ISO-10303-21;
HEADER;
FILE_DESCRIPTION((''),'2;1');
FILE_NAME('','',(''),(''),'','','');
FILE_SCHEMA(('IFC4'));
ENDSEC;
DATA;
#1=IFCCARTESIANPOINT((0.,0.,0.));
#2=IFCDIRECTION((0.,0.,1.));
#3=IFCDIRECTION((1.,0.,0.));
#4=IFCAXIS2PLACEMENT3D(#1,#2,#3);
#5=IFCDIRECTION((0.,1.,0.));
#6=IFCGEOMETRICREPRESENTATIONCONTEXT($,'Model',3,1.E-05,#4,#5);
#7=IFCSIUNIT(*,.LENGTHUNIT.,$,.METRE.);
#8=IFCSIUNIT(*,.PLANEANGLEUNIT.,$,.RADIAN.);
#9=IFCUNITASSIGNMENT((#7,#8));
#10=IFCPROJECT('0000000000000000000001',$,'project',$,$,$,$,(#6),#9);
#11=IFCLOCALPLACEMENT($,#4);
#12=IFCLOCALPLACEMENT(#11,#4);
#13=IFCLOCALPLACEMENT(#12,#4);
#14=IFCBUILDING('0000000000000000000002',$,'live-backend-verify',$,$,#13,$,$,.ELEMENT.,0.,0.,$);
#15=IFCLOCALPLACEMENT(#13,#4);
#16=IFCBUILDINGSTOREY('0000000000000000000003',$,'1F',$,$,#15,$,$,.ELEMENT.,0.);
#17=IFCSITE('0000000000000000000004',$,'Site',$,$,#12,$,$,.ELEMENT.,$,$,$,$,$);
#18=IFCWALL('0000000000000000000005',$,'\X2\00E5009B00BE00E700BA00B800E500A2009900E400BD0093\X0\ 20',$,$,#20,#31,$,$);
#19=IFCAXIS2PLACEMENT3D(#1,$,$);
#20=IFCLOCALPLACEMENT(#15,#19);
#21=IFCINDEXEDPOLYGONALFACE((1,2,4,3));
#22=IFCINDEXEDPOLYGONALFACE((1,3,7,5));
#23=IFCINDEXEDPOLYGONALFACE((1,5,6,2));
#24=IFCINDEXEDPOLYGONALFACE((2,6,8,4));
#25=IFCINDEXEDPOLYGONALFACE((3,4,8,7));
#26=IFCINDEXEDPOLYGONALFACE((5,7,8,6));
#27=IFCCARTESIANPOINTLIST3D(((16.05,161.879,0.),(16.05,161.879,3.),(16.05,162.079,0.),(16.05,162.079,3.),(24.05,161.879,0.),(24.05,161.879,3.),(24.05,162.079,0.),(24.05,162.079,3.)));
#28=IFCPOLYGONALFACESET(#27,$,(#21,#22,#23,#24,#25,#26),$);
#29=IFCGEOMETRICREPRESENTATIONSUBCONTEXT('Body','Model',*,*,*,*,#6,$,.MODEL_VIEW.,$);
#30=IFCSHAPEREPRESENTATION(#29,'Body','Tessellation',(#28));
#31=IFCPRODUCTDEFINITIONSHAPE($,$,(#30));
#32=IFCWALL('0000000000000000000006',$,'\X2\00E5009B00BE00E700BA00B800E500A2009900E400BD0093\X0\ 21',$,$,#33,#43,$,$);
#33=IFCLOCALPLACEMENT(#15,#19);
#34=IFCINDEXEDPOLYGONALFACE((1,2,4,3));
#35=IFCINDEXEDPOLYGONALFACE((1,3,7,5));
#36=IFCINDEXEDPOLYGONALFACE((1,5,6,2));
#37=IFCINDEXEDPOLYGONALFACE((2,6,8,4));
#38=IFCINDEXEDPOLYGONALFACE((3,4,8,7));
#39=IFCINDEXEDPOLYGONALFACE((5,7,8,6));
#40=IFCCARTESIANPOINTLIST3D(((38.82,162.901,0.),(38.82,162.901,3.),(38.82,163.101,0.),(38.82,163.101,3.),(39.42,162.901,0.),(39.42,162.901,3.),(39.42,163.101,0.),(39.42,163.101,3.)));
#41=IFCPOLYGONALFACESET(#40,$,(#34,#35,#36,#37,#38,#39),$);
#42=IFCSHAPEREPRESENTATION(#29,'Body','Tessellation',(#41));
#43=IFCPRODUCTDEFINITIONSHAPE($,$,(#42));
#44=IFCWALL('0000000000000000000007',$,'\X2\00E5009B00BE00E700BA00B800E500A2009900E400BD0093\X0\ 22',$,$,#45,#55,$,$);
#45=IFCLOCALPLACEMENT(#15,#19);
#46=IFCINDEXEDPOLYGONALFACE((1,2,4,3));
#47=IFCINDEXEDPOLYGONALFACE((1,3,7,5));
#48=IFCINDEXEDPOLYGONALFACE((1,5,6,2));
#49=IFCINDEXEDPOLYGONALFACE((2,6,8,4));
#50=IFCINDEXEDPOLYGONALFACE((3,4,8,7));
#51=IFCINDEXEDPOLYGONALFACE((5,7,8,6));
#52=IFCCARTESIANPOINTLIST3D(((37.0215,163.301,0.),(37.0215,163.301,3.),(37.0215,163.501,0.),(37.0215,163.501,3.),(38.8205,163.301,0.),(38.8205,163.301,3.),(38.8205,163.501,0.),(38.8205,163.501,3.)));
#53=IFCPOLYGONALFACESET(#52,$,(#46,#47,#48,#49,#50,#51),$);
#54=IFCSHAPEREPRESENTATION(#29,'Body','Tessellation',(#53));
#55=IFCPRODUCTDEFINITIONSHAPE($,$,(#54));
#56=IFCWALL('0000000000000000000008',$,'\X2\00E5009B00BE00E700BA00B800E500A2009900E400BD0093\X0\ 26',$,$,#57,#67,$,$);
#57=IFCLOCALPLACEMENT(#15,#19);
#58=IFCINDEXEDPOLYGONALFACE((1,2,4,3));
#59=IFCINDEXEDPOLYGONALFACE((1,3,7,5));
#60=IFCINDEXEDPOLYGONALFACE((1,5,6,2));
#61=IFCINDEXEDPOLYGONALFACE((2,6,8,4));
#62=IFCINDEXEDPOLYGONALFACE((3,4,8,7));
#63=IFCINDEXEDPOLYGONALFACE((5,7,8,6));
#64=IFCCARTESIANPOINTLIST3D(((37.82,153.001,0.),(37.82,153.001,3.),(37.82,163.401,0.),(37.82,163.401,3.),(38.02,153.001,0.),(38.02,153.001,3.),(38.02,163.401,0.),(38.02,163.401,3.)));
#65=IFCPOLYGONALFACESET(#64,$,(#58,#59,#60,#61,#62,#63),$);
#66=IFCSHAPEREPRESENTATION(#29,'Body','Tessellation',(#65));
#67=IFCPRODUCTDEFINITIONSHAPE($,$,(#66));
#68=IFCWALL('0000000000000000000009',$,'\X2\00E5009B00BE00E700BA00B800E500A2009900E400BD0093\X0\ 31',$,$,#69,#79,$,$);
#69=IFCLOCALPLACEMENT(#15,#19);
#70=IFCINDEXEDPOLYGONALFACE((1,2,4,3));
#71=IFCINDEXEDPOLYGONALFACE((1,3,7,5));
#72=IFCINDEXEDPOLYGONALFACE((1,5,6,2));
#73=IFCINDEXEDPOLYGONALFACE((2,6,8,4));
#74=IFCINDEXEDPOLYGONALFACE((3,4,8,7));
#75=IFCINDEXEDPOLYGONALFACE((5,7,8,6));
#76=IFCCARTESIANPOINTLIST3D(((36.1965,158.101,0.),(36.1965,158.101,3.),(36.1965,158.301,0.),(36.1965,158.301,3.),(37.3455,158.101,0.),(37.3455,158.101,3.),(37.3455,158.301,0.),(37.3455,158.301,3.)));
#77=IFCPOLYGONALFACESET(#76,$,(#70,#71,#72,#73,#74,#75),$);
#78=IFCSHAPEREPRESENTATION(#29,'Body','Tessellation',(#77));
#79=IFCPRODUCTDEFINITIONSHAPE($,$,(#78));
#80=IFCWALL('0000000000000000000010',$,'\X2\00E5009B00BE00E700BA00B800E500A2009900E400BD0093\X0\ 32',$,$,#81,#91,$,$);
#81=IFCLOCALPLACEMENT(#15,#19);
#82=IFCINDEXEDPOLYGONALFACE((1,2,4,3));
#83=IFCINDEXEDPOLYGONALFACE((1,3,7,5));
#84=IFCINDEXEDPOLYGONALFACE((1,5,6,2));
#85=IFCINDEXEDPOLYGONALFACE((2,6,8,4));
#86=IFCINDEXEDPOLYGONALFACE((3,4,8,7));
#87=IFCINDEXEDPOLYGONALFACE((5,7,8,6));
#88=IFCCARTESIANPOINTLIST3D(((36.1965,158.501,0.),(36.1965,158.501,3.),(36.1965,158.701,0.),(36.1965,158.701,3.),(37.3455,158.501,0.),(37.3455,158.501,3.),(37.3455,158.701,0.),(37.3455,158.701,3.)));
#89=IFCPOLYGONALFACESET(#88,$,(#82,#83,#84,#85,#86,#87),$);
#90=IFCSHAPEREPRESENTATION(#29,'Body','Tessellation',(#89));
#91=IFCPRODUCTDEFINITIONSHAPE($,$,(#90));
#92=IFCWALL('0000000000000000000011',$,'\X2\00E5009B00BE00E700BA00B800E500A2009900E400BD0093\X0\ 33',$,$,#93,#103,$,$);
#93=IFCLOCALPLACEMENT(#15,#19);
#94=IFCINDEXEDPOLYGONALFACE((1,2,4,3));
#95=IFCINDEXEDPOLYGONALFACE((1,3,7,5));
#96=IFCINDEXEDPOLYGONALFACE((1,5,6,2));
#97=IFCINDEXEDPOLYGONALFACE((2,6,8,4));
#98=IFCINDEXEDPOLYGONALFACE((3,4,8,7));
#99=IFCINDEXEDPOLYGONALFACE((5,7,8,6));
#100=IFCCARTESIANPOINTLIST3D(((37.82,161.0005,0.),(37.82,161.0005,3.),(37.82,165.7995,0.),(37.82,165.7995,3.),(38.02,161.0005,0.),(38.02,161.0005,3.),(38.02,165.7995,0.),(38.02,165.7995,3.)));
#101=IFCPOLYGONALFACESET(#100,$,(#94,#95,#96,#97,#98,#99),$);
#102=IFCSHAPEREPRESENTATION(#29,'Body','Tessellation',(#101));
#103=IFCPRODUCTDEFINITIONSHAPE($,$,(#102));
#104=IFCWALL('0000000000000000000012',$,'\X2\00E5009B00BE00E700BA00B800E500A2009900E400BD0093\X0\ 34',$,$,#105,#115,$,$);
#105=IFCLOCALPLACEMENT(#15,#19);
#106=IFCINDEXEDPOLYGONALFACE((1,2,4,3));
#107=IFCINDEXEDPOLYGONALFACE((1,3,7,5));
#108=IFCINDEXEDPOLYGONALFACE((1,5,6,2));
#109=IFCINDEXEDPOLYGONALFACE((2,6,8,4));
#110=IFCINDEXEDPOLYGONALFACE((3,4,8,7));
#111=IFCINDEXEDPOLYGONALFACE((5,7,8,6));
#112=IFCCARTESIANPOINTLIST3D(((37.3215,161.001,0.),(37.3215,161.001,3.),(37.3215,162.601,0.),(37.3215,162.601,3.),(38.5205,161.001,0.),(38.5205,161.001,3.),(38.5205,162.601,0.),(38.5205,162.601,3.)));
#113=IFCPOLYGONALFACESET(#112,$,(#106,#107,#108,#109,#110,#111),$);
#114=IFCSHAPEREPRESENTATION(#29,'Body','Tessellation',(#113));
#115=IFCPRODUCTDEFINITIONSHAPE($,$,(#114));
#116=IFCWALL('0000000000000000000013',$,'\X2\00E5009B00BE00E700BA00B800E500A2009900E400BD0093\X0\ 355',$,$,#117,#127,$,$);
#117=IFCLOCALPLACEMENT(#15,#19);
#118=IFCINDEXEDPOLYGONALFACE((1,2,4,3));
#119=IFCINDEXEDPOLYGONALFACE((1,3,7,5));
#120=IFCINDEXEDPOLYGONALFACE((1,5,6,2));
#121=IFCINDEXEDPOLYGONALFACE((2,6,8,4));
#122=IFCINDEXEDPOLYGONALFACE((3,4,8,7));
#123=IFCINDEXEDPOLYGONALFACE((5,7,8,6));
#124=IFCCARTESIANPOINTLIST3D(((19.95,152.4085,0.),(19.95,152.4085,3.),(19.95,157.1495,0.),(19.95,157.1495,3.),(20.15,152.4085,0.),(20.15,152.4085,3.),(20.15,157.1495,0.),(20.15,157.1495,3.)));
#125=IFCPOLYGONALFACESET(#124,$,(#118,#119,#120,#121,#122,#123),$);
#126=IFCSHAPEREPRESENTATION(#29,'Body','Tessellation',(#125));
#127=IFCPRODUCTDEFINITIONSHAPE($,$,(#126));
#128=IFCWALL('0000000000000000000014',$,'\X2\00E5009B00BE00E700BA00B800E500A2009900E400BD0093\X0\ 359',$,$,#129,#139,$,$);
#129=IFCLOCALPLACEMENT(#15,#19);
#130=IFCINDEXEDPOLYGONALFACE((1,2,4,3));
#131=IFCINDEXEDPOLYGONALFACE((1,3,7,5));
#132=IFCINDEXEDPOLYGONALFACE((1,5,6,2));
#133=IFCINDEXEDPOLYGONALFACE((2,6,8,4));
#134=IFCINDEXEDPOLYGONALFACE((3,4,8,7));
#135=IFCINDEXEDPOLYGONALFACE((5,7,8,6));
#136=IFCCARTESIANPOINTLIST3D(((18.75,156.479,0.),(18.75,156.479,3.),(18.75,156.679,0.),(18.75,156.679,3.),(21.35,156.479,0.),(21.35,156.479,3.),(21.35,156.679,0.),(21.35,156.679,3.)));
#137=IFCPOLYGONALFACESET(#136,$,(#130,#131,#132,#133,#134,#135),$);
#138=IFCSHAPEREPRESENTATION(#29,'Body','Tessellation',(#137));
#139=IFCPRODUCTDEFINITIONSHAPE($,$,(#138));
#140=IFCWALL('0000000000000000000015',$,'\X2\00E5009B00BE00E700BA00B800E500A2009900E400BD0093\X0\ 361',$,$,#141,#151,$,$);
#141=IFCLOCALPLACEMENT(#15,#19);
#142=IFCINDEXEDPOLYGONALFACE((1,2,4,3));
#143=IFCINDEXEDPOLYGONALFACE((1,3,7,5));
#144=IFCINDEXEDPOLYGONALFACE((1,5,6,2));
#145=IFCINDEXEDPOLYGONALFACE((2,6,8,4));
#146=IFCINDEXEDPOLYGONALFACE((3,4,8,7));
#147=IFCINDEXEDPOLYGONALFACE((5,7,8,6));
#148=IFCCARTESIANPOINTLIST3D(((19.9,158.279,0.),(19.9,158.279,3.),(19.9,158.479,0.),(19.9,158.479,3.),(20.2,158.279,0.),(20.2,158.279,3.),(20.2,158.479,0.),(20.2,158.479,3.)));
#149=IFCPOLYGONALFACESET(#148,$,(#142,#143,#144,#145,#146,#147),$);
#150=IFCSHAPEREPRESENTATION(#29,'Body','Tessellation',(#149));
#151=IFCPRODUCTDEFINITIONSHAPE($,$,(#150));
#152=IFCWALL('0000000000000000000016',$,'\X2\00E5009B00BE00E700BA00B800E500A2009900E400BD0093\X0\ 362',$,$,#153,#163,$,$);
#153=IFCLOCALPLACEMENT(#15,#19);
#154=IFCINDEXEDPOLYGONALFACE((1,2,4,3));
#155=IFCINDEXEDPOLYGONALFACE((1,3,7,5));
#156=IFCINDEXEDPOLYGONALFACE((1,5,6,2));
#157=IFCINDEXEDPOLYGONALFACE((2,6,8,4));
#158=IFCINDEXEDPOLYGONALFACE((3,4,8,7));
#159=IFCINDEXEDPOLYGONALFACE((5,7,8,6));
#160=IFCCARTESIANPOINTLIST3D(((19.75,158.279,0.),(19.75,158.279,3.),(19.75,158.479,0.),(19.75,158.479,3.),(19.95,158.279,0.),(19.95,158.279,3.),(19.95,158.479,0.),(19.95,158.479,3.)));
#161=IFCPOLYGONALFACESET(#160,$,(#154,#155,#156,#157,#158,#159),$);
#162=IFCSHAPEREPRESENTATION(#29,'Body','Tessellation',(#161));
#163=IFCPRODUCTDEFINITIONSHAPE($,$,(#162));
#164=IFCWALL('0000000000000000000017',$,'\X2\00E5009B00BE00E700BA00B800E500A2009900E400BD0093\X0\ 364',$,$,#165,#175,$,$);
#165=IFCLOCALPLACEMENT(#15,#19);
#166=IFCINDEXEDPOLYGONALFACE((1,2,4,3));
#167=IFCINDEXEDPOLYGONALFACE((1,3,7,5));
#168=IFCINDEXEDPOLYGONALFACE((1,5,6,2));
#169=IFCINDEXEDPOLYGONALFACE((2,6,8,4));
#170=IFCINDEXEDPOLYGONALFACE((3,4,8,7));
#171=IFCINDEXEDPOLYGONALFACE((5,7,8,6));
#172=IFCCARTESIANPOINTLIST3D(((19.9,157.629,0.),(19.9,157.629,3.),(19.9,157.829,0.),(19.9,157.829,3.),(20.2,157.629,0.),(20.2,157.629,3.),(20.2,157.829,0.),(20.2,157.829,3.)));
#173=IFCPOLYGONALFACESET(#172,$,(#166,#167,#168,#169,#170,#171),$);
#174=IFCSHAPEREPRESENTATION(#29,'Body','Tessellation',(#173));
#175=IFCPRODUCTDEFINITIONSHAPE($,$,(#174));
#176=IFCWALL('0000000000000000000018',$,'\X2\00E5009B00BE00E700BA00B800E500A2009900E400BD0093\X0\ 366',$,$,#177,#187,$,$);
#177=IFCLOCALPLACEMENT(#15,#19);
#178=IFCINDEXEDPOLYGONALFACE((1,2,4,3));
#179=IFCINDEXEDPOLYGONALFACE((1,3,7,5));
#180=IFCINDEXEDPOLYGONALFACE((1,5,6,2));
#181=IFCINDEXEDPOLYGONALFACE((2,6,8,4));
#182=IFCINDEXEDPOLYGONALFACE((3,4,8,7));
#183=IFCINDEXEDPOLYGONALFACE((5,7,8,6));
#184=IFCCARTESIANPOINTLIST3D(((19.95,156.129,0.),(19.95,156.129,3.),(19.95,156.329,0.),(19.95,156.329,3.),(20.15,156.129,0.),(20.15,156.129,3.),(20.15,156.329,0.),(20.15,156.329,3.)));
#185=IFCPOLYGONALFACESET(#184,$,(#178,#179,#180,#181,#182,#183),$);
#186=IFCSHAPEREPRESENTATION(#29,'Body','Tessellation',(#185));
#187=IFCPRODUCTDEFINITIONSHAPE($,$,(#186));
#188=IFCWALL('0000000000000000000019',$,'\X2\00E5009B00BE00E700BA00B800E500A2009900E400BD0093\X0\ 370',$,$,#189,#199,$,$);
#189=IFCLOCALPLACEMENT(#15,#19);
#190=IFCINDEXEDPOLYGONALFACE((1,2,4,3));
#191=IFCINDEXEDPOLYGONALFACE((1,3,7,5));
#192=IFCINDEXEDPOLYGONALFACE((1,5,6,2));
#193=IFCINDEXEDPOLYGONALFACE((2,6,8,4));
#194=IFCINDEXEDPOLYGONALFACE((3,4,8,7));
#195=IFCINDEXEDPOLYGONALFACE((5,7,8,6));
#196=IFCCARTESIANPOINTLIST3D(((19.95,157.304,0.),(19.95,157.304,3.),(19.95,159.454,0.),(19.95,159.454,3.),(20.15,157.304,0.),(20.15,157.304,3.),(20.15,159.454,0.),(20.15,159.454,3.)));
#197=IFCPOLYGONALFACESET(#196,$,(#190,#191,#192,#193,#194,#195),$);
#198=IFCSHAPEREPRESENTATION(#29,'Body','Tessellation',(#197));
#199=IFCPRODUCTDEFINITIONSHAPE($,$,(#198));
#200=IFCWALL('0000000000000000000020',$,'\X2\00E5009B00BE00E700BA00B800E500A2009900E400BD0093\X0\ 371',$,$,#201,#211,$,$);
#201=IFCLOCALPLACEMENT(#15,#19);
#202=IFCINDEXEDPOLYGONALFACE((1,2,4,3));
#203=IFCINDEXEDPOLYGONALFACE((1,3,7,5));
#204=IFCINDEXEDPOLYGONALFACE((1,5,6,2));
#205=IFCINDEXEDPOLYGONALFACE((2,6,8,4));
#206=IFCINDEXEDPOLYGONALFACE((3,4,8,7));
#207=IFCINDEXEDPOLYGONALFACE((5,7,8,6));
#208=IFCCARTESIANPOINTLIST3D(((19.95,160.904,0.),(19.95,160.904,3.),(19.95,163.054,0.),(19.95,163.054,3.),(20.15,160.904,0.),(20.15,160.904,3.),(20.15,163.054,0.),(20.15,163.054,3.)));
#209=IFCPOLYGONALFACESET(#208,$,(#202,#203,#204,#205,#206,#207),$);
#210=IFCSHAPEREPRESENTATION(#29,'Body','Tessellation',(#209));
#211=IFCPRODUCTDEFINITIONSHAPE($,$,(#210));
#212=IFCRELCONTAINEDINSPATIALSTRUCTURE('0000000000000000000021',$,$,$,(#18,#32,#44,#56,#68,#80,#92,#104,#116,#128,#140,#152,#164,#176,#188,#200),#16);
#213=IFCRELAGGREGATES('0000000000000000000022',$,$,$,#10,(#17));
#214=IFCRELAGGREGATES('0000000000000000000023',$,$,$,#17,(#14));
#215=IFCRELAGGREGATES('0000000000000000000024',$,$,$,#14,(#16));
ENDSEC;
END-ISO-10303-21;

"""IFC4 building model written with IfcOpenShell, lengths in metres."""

from ifc_helpers import new_model, si_unit, direction, frame, frame_2d, origin_with_axes, place, context, subcontext, project, spatial, rectangle, extrude, element, save


model = new_model("IFC4")

# Units and contexts
model_context = context("Model", 3, precision=1e-05, world=origin_with_axes(), true_north=direction((0.0, 1.0, 0.0)))
body_context = subcontext(model_context, "Body", "Model", "MODEL_VIEW")
ifc_project = project(units=[si_unit("LENGTHUNIT", "METRE"), si_unit("PLANEANGLEUNIT", "RADIAN")], contexts=[model_context])

# Site, building, storey
placement = place(None, origin_with_axes())
site_placement = place(placement, origin_with_axes())
site = spatial("IfcSite", under=ifc_project, at=site_placement, Name="Site", CompositionType="ELEMENT")
building_placement = place(site_placement, origin_with_axes())
building = spatial("IfcBuilding", under=site, at=building_placement, Name="live-backend-verify", CompositionType="ELEMENT", ElevationOfRefHeight=0.0, ElevationOfTerrain=0.0)
storey_placement = place(building_placement, origin_with_axes())
storey = spatial("IfcBuildingStorey", under=building, at=storey_placement, Name="1F", CompositionType="ELEMENT", Elevation=0.0)

# Walls
wall_1_placement = place(storey_placement, frame((20.05, 161.979, 0.0), z_axis=(0.0, 0.0, 1.0), x_axis=(-1.0, 0.0, 0.0)))
element("IfcWall", 1, at=wall_1_placement, inside=storey, Name="å\u009b¾çº¸å¢\u0099ä½\u0093 20", context=body_context, shape_type="SweptSolid", body=[
    extrude(rectangle(XDim=8.0, YDim=0.2, at=frame_2d((0.0, 0.0), x_axis=(1.0, 0.0, 0.0))), frame((0.0, 0.0, 0.0), z_axis=(0.0, 0.0, 1.0)), (0.0, 0.0, 1.0), 3.0),
])
wall_2_placement = place(storey_placement, frame((39.12, 163.001, 0.0), z_axis=(0.0, 0.0, 1.0), x_axis=(1.0, 0.0, 0.0)))
element("IfcWall", 2, at=wall_2_placement, inside=storey, Name="å\u009b¾çº¸å¢\u0099ä½\u0093 21", context=body_context, shape_type="SweptSolid", body=[
    extrude(rectangle(XDim=0.6, YDim=0.2, at=frame_2d((0.0, 0.0), x_axis=(1.0, 0.0, 0.0))), frame((0.0, 0.0, 0.0), z_axis=(0.0, 0.0, 1.0)), (0.0, 0.0, 1.0), 3.0),
])
wall_3_placement = place(storey_placement, frame((37.921, 163.401, 0.0), z_axis=(0.0, 0.0, 1.0), x_axis=(1.0, 0.0, 0.0)))
element("IfcWall", 3, at=wall_3_placement, inside=storey, Name="å\u009b¾çº¸å¢\u0099ä½\u0093 22", context=body_context, shape_type="SweptSolid", body=[
    extrude(rectangle(XDim=1.799, YDim=0.2, at=frame_2d((0.0, 0.0), x_axis=(1.0, 0.0, 0.0))), frame((0.0, 0.0, 0.0), z_axis=(0.0, 0.0, 1.0)), (0.0, 0.0, 1.0), 3.0),
])
wall_4_placement = place(storey_placement, frame((37.92, 158.201, 0.0), z_axis=(0.0, 0.0, 1.0), x_axis=(0.0, -1.0, 0.0)))
element("IfcWall", 4, at=wall_4_placement, inside=storey, Name="å\u009b¾çº¸å¢\u0099ä½\u0093 26", context=body_context, shape_type="SweptSolid", body=[
    extrude(rectangle(XDim=10.4, YDim=0.2, at=frame_2d((0.0, 0.0), x_axis=(1.0, 0.0, 0.0))), frame((0.0, 0.0, 0.0), z_axis=(0.0, 0.0, 1.0)), (0.0, 0.0, 1.0), 3.0),
])
for number, where, z_axis, x_axis, name in (
    (5, (36.771, 158.201, 0.0), (0.0, 0.0, 1.0), (1.0, 0.0, 0.0), "å\u009b¾çº¸å¢\u0099ä½\u0093 31"),
    (6, (36.771, 158.601, 0.0), (0.0, 0.0, 1.0), (1.0, 0.0, 0.0), "å\u009b¾çº¸å¢\u0099ä½\u0093 32"),
):
    element("IfcWall", number, at=place(storey_placement, frame(where, z_axis=z_axis, x_axis=x_axis)), inside=storey, Name=name, context=body_context, shape_type="SweptSolid", body=[
        extrude(rectangle(XDim=1.149, YDim=0.2, at=frame_2d((0.0, 0.0), x_axis=(1.0, 0.0, 0.0))), frame((0.0, 0.0, 0.0), z_axis=(0.0, 0.0, 1.0)), (0.0, 0.0, 1.0), 3.0),
    ])
wall_5_placement = place(storey_placement, frame((37.92, 163.4, 0.0), z_axis=(0.0, 0.0, 1.0), x_axis=(0.0, -1.0, 0.0)))
element("IfcWall", 7, at=wall_5_placement, inside=storey, Name="å\u009b¾çº¸å¢\u0099ä½\u0093 33", context=body_context, shape_type="SweptSolid", body=[
    extrude(rectangle(XDim=4.799, YDim=0.2, at=frame_2d((0.0, 0.0), x_axis=(1.0, 0.0, 0.0))), frame((0.0, 0.0, 0.0), z_axis=(0.0, 0.0, 1.0)), (0.0, 0.0, 1.0), 3.0),
])
wall_6_placement = place(storey_placement, frame((37.921, 161.801, 0.0), z_axis=(0.0, 0.0, 1.0), x_axis=(1.0, 0.0, 0.0)))
element("IfcWall", 8, at=wall_6_placement, inside=storey, Name="å\u009b¾çº¸å¢\u0099ä½\u0093 34", context=body_context, shape_type="SweptSolid", body=[
    extrude(rectangle(XDim=1.199, YDim=1.6, at=frame_2d((0.0, 0.0), x_axis=(1.0, 0.0, 0.0))), frame((0.0, 0.0, 0.0), z_axis=(0.0, 0.0, 1.0)), (0.0, 0.0, 1.0), 3.0),
])
wall_7_placement = place(storey_placement, frame((20.05, 154.779, 0.0), z_axis=(0.0, 0.0, 1.0), x_axis=(0.0, -1.0, 0.0)))
element("IfcWall", 9, at=wall_7_placement, inside=storey, Name="å\u009b¾çº¸å¢\u0099ä½\u0093 355", context=body_context, shape_type="SweptSolid", body=[
    extrude(rectangle(XDim=4.741, YDim=0.2, at=frame_2d((0.0, 0.0), x_axis=(1.0, 0.0, 0.0))), frame((0.0, 0.0, 0.0), z_axis=(0.0, 0.0, 1.0)), (0.0, 0.0, 1.0), 3.0),
])
wall_8_placement = place(storey_placement, frame((20.05, 156.579, 0.0), z_axis=(0.0, 0.0, 1.0), x_axis=(-1.0, 0.0, 0.0)))
element("IfcWall", 10, at=wall_8_placement, inside=storey, Name="å\u009b¾çº¸å¢\u0099ä½\u0093 359", context=body_context, shape_type="SweptSolid", body=[
    extrude(rectangle(XDim=2.6, YDim=0.2, at=frame_2d((0.0, 0.0), x_axis=(1.0, 0.0, 0.0))), frame((0.0, 0.0, 0.0), z_axis=(0.0, 0.0, 1.0)), (0.0, 0.0, 1.0), 3.0),
])
wall_9_placement = place(storey_placement, frame((20.05, 158.379, 0.0), z_axis=(0.0, 0.0, 1.0), x_axis=(-1.0, 0.0, 0.0)))
element("IfcWall", 11, at=wall_9_placement, inside=storey, Name="å\u009b¾çº¸å¢\u0099ä½\u0093 361", context=body_context, shape_type="SweptSolid", body=[
    extrude(rectangle(XDim=0.3, YDim=0.2, at=frame_2d((0.0, 0.0), x_axis=(1.0, 0.0, 0.0))), frame((0.0, 0.0, 0.0), z_axis=(0.0, 0.0, 1.0)), (0.0, 0.0, 1.0), 3.0),
])
wall_10_placement = place(storey_placement, frame((19.85, 158.379, 0.0), z_axis=(0.0, 0.0, 1.0), x_axis=(1.0, 0.0, 0.0)))
element("IfcWall", 12, at=wall_10_placement, inside=storey, Name="å\u009b¾çº¸å¢\u0099ä½\u0093 362", context=body_context, shape_type="SweptSolid", body=[
    extrude(rectangle(XDim=0.2, YDim=0.2, at=frame_2d((0.0, 0.0), x_axis=(1.0, 0.0, 0.0))), frame((0.0, 0.0, 0.0), z_axis=(0.0, 0.0, 1.0)), (0.0, 0.0, 1.0), 3.0),
])
for number, where, z_axis, x_axis, name in (
    (13, (20.05, 157.729, 0.0), (0.0, 0.0, 1.0), (-1.0, 0.0, 0.0), "å\u009b¾çº¸å¢\u0099ä½\u0093 364"),
):
    element("IfcWall", number, at=place(storey_placement, frame(where, z_axis=z_axis, x_axis=x_axis)), inside=storey, Name=name, context=body_context, shape_type="SweptSolid", body=[
        extrude(rectangle(XDim=0.3, YDim=0.2, at=frame_2d((0.0, 0.0), x_axis=(1.0, 0.0, 0.0))), frame((0.0, 0.0, 0.0), z_axis=(0.0, 0.0, 1.0)), (0.0, 0.0, 1.0), 3.0),
    ])
wall_11_placement = place(storey_placement, frame((20.05, 156.229, 0.0), z_axis=(0.0, 0.0, 1.0), x_axis=(-1.0, 0.0, 0.0)))
element("IfcWall", 14, at=wall_11_placement, inside=storey, Name="å\u009b¾çº¸å¢\u0099ä½\u0093 366", context=body_context, shape_type="SweptSolid", body=[
    extrude(rectangle(XDim=0.2, YDim=0.2, at=frame_2d((0.0, 0.0), x_axis=(1.0, 0.0, 0.0))), frame((0.0, 0.0, 0.0), z_axis=(0.0, 0.0, 1.0)), (0.0, 0.0, 1.0), 3.0),
])
for number, where, z_axis, x_axis, name in (
    (15, (20.05, 158.379, 0.0), (0.0, 0.0, 1.0), (0.0, -1.0, 0.0), "å\u009b¾çº¸å¢\u0099ä½\u0093 370"),
    (16, (20.05, 161.979, 0.0), (0.0, 0.0, 1.0), (0.0, -1.0, 0.0), "å\u009b¾çº¸å¢\u0099ä½\u0093 371"),
):
    element("IfcWall", number, at=place(storey_placement, frame(where, z_axis=z_axis, x_axis=x_axis)), inside=storey, Name=name, context=body_context, shape_type="SweptSolid", body=[
        extrude(rectangle(XDim=2.15, YDim=0.2, at=frame_2d((0.0, 0.0), x_axis=(1.0, 0.0, 0.0))), frame((0.0, 0.0, 0.0), z_axis=(0.0, 0.0, 1.0)), (0.0, 0.0, 1.0), 3.0),
    ])

save(model, "model.ifc")
